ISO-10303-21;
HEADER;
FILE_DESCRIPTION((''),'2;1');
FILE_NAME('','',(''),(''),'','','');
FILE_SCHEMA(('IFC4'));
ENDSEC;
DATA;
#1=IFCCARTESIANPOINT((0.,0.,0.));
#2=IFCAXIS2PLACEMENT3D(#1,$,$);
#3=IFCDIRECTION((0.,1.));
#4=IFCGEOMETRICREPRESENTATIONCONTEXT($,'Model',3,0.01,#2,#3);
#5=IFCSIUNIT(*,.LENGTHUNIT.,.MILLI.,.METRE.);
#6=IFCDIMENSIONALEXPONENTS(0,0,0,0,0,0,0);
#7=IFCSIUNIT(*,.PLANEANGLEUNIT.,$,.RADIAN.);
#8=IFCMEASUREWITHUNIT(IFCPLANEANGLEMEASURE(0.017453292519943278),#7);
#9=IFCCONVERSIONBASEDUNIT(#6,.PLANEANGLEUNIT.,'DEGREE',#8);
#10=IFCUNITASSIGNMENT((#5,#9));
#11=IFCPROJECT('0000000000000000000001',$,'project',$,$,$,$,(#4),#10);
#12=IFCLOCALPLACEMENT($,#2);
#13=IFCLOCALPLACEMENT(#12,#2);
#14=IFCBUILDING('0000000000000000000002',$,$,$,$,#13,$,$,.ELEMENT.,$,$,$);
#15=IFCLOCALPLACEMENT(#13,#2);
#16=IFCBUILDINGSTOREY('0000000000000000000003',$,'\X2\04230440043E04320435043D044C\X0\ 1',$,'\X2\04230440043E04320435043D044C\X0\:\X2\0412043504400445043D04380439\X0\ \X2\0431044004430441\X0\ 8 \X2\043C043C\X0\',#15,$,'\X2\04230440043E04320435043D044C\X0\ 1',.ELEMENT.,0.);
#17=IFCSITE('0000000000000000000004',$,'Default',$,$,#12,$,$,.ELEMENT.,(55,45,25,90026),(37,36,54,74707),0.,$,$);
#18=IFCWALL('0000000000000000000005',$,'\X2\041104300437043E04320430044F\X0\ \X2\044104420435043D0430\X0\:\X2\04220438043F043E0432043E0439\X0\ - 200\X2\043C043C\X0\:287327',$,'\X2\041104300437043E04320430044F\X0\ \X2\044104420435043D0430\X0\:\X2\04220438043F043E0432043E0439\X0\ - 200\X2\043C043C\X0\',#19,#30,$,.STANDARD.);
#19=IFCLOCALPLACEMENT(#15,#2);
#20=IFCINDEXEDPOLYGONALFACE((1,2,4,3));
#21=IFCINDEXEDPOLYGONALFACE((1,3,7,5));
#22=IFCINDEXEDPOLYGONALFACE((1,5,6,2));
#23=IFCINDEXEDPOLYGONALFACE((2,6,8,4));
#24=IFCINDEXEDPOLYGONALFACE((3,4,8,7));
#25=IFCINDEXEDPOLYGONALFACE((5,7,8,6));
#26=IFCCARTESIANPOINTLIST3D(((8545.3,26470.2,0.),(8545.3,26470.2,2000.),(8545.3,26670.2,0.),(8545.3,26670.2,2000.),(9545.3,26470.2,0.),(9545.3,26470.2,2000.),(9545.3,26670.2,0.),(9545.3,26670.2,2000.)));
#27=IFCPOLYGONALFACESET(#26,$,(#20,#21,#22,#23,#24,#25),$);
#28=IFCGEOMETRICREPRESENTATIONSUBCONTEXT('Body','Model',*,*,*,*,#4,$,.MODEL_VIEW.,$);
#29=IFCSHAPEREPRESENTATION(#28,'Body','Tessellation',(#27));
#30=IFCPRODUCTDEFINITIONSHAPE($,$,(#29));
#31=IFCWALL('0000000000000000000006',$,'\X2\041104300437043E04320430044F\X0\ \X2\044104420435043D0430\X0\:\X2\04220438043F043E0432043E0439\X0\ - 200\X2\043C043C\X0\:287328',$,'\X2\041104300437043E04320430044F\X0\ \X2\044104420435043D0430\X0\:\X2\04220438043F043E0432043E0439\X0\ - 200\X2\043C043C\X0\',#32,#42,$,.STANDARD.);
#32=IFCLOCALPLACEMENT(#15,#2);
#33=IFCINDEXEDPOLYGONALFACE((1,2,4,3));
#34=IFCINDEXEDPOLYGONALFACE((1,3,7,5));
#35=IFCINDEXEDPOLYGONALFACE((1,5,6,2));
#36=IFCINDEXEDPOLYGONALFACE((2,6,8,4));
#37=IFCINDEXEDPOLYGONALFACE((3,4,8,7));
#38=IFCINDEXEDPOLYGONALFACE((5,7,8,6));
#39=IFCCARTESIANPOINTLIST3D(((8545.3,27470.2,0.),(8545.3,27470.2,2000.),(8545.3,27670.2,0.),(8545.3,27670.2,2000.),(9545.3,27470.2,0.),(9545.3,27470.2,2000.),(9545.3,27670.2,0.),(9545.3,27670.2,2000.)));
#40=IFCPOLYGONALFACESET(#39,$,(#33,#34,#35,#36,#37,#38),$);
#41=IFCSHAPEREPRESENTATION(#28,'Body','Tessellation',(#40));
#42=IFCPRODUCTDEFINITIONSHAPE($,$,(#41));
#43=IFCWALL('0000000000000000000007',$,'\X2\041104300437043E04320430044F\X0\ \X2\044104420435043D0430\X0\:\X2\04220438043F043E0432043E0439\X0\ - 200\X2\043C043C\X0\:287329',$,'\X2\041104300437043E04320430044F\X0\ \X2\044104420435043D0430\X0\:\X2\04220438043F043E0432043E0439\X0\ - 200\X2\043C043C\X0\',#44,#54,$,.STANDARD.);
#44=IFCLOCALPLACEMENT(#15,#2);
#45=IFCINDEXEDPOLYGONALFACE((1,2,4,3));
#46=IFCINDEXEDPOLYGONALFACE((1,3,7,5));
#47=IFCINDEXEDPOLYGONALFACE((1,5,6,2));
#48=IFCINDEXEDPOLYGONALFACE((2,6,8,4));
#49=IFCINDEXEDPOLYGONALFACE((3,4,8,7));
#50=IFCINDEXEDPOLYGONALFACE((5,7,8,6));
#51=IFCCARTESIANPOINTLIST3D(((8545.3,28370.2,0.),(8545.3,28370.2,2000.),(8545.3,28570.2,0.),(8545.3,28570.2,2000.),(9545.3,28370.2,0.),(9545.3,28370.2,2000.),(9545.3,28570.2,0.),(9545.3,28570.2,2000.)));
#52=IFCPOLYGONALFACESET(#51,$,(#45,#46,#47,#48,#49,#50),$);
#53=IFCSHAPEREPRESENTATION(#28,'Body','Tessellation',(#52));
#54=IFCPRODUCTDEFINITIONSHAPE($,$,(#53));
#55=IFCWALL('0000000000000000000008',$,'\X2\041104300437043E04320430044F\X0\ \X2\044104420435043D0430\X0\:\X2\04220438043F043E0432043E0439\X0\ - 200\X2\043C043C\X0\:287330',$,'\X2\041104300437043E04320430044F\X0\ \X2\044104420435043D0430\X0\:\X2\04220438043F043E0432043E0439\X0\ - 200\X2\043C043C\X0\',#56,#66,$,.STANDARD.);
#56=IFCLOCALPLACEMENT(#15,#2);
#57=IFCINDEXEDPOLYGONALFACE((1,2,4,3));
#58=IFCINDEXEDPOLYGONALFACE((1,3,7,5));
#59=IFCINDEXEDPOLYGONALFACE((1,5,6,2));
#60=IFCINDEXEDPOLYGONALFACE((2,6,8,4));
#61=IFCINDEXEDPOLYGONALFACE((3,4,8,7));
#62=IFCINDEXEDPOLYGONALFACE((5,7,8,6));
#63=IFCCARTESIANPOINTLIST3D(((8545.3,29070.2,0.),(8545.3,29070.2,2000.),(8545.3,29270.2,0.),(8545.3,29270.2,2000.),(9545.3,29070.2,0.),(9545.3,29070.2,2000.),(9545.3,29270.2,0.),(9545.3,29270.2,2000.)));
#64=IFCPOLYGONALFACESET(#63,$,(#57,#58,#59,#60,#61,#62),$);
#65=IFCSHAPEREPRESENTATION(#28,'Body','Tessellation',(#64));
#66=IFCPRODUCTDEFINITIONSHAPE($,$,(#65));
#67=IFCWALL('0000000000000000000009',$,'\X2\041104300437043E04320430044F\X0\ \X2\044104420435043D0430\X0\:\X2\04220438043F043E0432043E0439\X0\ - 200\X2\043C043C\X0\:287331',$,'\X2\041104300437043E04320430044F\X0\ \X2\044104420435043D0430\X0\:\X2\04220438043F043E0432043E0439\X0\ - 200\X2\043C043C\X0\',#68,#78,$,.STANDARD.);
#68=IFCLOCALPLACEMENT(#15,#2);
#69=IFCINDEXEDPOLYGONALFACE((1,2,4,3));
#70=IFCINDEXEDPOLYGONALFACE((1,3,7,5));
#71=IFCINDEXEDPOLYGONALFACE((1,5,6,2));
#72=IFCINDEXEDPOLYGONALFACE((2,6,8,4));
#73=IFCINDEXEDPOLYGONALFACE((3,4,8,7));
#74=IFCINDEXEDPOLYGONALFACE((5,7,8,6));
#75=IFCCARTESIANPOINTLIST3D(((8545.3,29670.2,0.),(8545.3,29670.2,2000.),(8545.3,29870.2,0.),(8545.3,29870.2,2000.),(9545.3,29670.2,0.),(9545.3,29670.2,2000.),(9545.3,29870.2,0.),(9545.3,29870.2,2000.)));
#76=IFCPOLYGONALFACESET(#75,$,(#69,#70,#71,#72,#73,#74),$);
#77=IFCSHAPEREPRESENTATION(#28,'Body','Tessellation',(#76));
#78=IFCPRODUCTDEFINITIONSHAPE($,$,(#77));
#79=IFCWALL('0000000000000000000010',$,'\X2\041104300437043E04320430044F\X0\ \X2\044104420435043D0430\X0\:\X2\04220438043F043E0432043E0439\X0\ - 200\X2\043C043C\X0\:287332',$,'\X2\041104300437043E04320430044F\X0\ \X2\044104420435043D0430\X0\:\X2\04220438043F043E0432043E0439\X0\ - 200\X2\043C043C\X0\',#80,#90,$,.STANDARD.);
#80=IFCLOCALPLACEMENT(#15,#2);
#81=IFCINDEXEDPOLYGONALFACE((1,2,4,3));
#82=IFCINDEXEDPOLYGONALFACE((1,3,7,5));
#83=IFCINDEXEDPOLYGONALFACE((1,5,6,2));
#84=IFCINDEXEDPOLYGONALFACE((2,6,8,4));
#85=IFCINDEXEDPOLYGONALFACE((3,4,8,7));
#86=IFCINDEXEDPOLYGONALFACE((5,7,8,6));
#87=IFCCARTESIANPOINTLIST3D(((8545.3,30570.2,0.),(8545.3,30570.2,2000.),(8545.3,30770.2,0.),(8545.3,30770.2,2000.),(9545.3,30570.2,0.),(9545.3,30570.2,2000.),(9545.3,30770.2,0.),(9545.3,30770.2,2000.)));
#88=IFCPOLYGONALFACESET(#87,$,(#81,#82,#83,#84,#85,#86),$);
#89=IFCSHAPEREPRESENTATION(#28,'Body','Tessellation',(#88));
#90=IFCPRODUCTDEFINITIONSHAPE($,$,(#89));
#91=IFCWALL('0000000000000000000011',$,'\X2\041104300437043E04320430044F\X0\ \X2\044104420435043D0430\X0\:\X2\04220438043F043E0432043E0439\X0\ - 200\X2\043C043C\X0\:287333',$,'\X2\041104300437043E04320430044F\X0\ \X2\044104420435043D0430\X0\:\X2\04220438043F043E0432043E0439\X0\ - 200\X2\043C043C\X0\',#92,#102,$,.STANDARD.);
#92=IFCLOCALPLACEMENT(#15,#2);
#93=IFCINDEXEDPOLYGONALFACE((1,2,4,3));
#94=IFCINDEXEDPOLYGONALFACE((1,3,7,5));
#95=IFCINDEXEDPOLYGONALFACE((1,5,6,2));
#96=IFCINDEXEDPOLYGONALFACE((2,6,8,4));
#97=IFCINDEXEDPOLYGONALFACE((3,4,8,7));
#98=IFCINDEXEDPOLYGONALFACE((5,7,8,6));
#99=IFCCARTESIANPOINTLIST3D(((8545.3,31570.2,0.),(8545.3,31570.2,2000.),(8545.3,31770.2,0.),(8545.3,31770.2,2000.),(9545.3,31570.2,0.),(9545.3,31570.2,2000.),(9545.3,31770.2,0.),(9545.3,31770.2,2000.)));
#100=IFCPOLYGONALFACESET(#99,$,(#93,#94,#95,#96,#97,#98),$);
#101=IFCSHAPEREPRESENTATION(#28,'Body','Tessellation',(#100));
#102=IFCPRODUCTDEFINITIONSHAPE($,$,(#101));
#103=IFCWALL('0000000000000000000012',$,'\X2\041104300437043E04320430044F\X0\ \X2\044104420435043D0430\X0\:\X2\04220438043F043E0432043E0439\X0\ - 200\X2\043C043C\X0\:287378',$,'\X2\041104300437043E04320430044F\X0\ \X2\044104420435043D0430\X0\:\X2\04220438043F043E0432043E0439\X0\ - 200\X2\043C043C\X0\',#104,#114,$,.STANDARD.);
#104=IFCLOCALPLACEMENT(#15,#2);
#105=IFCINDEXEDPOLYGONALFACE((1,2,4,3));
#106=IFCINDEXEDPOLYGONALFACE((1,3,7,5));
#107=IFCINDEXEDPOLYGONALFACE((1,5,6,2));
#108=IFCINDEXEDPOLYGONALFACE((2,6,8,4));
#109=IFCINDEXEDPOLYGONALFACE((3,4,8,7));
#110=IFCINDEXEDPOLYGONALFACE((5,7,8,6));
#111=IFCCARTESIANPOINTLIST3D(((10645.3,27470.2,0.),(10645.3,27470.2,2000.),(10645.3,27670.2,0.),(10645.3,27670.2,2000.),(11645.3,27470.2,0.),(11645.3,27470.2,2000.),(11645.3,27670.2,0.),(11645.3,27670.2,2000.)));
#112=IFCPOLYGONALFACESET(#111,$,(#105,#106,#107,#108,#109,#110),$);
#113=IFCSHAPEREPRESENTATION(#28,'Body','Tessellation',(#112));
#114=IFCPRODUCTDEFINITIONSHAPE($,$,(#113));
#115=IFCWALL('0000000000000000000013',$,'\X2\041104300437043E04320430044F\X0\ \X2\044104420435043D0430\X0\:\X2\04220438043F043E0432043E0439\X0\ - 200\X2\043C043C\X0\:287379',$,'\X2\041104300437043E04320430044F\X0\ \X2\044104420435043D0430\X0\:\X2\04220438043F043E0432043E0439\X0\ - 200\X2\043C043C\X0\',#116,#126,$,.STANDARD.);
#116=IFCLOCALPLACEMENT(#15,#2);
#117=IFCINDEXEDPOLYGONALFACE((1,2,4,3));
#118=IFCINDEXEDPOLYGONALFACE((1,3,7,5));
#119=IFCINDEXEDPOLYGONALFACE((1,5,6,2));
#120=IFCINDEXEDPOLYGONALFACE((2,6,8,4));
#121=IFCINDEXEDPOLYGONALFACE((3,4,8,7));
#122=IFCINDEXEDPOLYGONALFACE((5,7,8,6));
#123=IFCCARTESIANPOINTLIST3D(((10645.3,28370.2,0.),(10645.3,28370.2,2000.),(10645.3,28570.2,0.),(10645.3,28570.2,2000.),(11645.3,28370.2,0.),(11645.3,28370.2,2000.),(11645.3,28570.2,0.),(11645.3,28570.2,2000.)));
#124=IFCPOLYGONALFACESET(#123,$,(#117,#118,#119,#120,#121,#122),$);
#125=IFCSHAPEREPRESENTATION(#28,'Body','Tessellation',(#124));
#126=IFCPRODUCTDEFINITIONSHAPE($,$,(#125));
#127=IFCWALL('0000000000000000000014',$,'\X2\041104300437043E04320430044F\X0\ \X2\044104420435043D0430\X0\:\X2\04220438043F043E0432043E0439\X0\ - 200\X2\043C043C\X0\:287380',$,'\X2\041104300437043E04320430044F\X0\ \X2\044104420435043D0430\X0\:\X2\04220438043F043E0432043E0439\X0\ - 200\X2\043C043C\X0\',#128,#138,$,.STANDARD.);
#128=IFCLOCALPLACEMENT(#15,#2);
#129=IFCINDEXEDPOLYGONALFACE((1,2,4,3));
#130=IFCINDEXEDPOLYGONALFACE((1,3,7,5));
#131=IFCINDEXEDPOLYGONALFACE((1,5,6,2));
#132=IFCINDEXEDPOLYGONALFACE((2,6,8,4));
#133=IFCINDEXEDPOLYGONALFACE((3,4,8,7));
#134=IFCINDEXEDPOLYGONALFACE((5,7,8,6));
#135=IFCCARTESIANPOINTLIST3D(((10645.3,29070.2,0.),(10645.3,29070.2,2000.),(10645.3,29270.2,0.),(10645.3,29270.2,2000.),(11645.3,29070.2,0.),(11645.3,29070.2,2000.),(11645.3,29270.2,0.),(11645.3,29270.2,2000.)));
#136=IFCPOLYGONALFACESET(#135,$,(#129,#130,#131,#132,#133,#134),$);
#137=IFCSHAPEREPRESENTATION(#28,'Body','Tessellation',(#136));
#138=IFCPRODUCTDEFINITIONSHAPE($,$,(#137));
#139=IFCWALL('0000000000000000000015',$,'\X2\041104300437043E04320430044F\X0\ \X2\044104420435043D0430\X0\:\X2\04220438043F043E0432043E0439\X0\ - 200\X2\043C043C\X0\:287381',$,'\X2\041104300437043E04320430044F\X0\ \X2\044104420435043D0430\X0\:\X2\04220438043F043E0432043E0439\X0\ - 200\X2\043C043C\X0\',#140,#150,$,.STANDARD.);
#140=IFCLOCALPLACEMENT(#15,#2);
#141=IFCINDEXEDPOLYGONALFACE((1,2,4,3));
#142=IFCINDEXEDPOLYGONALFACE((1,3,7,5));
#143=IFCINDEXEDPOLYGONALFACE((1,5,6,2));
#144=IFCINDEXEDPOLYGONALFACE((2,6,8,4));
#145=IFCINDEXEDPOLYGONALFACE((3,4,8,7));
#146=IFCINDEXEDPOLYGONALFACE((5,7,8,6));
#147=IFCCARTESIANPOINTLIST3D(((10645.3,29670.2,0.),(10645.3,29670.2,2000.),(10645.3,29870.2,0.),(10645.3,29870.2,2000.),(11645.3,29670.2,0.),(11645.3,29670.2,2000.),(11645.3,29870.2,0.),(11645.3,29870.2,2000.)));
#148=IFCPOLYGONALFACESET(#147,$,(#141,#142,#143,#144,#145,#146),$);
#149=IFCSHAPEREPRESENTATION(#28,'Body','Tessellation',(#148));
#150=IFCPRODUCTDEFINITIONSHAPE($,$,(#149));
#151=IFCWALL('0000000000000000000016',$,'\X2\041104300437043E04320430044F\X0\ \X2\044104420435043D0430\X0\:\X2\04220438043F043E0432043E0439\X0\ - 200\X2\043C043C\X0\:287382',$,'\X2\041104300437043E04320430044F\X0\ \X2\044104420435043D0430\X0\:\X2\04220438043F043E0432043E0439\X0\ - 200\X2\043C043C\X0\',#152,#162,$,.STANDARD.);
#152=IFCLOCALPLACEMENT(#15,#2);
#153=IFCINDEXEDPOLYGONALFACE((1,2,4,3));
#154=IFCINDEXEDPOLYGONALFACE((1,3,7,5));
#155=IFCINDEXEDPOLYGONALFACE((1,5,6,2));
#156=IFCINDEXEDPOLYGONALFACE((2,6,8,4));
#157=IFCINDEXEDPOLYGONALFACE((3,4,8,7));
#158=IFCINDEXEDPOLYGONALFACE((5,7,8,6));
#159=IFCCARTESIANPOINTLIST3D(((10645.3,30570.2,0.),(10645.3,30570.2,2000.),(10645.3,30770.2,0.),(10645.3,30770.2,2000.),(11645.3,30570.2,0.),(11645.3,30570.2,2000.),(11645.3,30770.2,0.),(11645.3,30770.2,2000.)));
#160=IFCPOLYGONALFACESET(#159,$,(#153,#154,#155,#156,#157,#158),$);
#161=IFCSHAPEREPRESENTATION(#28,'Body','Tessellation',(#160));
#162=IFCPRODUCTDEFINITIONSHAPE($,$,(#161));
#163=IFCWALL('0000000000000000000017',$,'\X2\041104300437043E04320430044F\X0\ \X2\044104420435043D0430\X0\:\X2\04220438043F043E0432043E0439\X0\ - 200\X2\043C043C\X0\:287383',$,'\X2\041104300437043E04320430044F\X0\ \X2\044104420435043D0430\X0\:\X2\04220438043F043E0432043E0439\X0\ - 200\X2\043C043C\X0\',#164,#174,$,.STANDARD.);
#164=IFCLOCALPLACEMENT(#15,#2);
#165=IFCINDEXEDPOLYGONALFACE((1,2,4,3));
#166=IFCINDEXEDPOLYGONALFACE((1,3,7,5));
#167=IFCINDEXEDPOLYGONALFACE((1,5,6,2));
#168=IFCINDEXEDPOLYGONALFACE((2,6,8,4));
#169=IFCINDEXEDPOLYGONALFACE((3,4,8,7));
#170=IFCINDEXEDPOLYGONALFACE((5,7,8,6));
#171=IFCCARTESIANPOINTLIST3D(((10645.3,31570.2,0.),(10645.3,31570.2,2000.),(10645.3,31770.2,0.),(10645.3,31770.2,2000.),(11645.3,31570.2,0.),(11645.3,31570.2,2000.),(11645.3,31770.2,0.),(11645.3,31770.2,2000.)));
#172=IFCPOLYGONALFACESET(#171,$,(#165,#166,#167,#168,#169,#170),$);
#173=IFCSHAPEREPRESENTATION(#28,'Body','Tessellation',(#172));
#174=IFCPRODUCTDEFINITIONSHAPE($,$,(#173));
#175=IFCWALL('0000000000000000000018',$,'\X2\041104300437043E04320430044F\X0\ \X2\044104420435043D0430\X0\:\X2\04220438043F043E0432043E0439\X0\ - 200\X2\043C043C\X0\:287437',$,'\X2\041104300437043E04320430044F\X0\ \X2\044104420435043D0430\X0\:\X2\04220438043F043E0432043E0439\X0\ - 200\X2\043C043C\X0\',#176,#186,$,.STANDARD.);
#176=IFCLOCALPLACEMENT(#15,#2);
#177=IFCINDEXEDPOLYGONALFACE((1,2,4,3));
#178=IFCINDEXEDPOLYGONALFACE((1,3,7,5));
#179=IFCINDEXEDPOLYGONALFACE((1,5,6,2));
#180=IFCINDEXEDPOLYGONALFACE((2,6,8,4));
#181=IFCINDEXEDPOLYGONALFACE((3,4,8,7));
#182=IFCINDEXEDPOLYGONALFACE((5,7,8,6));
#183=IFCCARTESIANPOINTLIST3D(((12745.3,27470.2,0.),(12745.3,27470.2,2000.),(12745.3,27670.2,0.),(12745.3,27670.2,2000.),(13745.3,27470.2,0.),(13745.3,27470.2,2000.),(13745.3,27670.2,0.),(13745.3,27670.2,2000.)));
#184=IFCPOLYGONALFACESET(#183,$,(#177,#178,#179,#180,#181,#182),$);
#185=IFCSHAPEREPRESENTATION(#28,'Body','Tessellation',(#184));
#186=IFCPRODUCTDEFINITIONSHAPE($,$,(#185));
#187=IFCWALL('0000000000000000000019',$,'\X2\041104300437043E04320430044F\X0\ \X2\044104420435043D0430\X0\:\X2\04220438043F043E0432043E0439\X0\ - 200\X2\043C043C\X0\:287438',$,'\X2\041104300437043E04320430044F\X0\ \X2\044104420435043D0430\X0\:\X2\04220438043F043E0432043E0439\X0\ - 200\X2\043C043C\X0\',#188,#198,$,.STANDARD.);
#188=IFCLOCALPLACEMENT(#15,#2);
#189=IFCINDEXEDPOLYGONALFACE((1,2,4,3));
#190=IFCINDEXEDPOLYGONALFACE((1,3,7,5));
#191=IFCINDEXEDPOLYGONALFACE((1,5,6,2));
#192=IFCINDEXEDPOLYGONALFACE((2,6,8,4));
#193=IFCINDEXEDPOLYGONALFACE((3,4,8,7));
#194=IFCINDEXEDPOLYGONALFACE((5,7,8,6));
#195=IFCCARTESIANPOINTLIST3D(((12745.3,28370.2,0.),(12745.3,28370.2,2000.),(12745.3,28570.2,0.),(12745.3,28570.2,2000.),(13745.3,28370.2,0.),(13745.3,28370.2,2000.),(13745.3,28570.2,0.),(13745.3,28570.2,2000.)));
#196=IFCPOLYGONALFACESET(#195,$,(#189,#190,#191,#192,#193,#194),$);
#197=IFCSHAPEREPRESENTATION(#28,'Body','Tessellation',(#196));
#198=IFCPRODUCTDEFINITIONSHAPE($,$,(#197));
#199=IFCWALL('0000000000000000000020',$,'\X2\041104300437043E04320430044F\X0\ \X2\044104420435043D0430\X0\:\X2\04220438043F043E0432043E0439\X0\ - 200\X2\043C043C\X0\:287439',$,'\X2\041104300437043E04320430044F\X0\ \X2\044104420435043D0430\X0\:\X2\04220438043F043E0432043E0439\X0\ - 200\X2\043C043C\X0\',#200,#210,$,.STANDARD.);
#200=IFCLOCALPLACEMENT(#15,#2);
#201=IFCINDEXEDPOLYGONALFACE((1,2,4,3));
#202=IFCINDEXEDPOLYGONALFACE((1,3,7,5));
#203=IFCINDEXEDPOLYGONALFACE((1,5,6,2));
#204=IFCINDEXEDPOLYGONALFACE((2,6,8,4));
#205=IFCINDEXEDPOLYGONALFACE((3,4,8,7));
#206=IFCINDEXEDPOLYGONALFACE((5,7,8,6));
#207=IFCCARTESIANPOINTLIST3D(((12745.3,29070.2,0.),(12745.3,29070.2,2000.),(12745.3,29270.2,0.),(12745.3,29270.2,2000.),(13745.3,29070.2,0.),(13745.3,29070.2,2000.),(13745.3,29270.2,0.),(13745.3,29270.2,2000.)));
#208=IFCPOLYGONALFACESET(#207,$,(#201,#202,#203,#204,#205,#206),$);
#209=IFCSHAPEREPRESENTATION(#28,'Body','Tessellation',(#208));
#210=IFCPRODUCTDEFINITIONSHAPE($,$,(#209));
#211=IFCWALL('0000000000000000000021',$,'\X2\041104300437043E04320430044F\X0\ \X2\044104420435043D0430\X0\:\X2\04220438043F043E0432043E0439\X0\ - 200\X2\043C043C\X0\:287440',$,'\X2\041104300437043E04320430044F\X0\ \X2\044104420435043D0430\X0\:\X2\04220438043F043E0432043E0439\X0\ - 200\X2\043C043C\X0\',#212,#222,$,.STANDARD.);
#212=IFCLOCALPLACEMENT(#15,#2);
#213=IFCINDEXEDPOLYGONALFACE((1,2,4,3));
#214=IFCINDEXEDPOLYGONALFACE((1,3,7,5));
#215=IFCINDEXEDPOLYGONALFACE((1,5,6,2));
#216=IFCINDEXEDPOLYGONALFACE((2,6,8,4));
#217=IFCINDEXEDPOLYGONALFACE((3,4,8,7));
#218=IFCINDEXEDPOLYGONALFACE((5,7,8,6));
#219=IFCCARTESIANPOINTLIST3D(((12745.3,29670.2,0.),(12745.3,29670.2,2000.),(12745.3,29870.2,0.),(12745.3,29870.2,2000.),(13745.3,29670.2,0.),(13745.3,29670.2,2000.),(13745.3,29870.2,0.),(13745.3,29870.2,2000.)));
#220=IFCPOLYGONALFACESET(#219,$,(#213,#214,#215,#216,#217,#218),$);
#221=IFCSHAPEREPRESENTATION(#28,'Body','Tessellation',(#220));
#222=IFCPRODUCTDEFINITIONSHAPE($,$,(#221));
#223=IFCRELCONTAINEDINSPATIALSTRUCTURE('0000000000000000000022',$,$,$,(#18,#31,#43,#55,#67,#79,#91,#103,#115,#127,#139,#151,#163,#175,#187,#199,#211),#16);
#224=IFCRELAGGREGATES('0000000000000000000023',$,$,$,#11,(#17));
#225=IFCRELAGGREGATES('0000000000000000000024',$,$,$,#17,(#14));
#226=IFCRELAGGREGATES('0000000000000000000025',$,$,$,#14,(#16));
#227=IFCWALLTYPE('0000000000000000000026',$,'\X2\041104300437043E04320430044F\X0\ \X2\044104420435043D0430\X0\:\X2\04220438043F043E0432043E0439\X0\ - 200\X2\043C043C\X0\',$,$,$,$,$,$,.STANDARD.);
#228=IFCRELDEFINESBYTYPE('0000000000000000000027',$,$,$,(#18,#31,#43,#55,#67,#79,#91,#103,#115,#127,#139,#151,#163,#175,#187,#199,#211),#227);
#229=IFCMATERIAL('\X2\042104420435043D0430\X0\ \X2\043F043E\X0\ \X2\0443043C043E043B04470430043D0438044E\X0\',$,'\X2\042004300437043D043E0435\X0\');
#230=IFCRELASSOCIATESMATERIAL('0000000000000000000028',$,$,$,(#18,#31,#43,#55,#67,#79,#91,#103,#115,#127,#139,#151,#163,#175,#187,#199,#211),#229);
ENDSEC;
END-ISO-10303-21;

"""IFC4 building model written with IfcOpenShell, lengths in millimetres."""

from ifc_helpers import new_model, entity, si_unit, converted_unit, direction, frame, origin, place, context, subcontext, project, spatial, indexed_curve, outline, extrude, material, type_object, element, save


model = new_model("IFC4")

# Units and contexts
model_context = context("Model", 3, precision=0.01, world=origin(), true_north=direction((0.0, 1.0)))
body_context = subcontext(model_context, "Body", "Model", "MODEL_VIEW")
ifc_project = project(units=[si_unit("LENGTHUNIT", "METRE", prefix="MILLI"), converted_unit("PLANEANGLEUNIT", "DEGREE", entity("IfcPlaneAngleMeasure", 0.017453292519943278), si_unit("PLANEANGLEUNIT", "RADIAN"), dimensions=[0, 0, 0, 0, 0, 0, 0])], contexts=[model_context])

# Site, building, storey
site_placement = place(None, origin())
site = spatial("IfcSite", under=ifc_project, at=site_placement, Name="Default", CompositionType="ELEMENT", RefLatitude=(55, 45, 25, 90026), RefLongitude=(37, 36, 54, 74707), RefElevation=0.0)
building_placement = place(site_placement, origin())
building = spatial("IfcBuilding", under=site, at=building_placement, CompositionType="ELEMENT")
storey_placement = place(building_placement, origin())
storey = spatial("IfcBuildingStorey", under=building, at=storey_placement, Name="Уровень 1", ObjectType="Уровень:Верхний брус 8 мм", LongName="Уровень 1", CompositionType="ELEMENT", Elevation=0.0)

# Walls
ifc_material = material(Name="Стена по умолчанию", Category="Разное")
wall_type = type_object("IfcWallType", Name="Базовая стена:Типовой - 200мм", PredefinedType="STANDARD")
for number, where, name in (
    (1, (8545.3, 26570.2, 0.0), "Базовая стена:Типовой - 200мм:287327"),
    (2, (8545.3, 27570.2, 0.0), "Базовая стена:Типовой - 200мм:287328"),
):
    element("IfcWall", number, at=place(storey_placement, frame(where)), inside=storey, type_object=wall_type, material=ifc_material, Name=name, ObjectType="Базовая стена:Типовой - 200мм", PredefinedType="STANDARD", context=body_context, shape_type="SweptSolid", body=[
        extrude(outline(indexed_curve([(1000.0, 100.0), (0.0, 100.0), (0.0, -100.0), (1000.0, -100.0), (1000.0, 100.0)], self_intersect=False)), origin(), (0.0, 0.0, 1.0), 2000.0),
    ])
for number, where, name in (
    (3, (8545.3, 28470.2, 0.0), "Базовая стена:Типовой - 200мм:287329"),
    (4, (8545.3, 29170.2, 0.0), "Базовая стена:Типовой - 200мм:287330"),
):
    element("IfcWall", number, at=place(storey_placement, frame(where)), inside=storey, type_object=wall_type, material=ifc_material, Name=name, ObjectType="Базовая стена:Типовой - 200мм", PredefinedType="STANDARD", context=body_context, shape_type="SweptSolid", body=[
        extrude(outline(indexed_curve([(1000.0, 100.0), (0.0, 100.0), (0.0, -100.0), (1000.0, -100.0), (1000.0, 100.0)], self_intersect=False)), origin(), (0.0, 0.0, 1.0), 2000.0),
    ])
for number, where, name in (
    (5, (8545.3, 29770.2, 0.0), "Базовая стена:Типовой - 200мм:287331"),
    (6, (8545.3, 30670.2, 0.0), "Базовая стена:Типовой - 200мм:287332"),
    (7, (8545.3, 31670.2, 0.0), "Базовая стена:Типовой - 200мм:287333"),
):
    element("IfcWall", number, at=place(storey_placement, frame(where)), inside=storey, type_object=wall_type, material=ifc_material, Name=name, ObjectType="Базовая стена:Типовой - 200мм", PredefinedType="STANDARD", context=body_context, shape_type="SweptSolid", body=[
        extrude(outline(indexed_curve([(1000.0, 100.0), (0.0, 100.0), (0.0, -100.0), (1000.0, -100.0), (1000.0, 100.0)], self_intersect=False)), origin(), (0.0, 0.0, 1.0), 2000.0),
    ])
wall_1_placement = place(storey_placement, frame((10645.3, 27570.2, 0.0)))
element("IfcWall", 8, at=wall_1_placement, inside=storey, type_object=wall_type, material=ifc_material, Name="Базовая стена:Типовой - 200мм:287378", ObjectType="Базовая стена:Типовой - 200мм", PredefinedType="STANDARD", context=body_context, shape_type="SweptSolid", body=[
    extrude(outline(indexed_curve([(1000.0, 100.0), (0.0, 100.0), (0.0, -100.0), (1000.0, -100.0), (1000.0, 100.0)], self_intersect=False)), origin(), (0.0, 0.0, 1.0), 2000.0),
])
for number, where, name in (
    (9, (10645.3, 28470.2, 0.0), "Базовая стена:Типовой - 200мм:287379"),
    (10, (10645.3, 29170.2, 0.0), "Базовая стена:Типовой - 200мм:287380"),
):
    element("IfcWall", number, at=place(storey_placement, frame(where)), inside=storey, type_object=wall_type, material=ifc_material, Name=name, ObjectType="Базовая стена:Типовой - 200мм", PredefinedType="STANDARD", context=body_context, shape_type="SweptSolid", body=[
        extrude(outline(indexed_curve([(1000.0, 100.0), (0.0, 100.0), (0.0, -100.0), (1000.0, -100.0), (1000.0, 100.0)], self_intersect=False)), origin(), (0.0, 0.0, 1.0), 2000.0),
    ])
for number, where, name in (
    (11, (10645.3, 29770.2, 0.0), "Базовая стена:Типовой - 200мм:287381"),
    (12, (10645.3, 30670.2, 0.0), "Базовая стена:Типовой - 200мм:287382"),
    (13, (10645.3, 31670.2, 0.0), "Базовая стена:Типовой - 200мм:287383"),
    (14, (12745.3, 27570.2, 0.0), "Базовая стена:Типовой - 200мм:287437"),
):
    element("IfcWall", number, at=place(storey_placement, frame(where)), inside=storey, type_object=wall_type, material=ifc_material, Name=name, ObjectType="Базовая стена:Типовой - 200мм", PredefinedType="STANDARD", context=body_context, shape_type="SweptSolid", body=[
        extrude(outline(indexed_curve([(1000.0, 100.0), (0.0, 100.0), (0.0, -100.0), (1000.0, -100.0), (1000.0, 100.0)], self_intersect=False)), origin(), (0.0, 0.0, 1.0), 2000.0),
    ])
for number, where, name in (
    (15, (12745.3, 28470.2, 0.0), "Базовая стена:Типовой - 200мм:287438"),
    (16, (12745.3, 29170.2, 0.0), "Базовая стена:Типовой - 200мм:287439"),
):
    element("IfcWall", number, at=place(storey_placement, frame(where)), inside=storey, type_object=wall_type, material=ifc_material, Name=name, ObjectType="Базовая стена:Типовой - 200мм", PredefinedType="STANDARD", context=body_context, shape_type="SweptSolid", body=[
        extrude(outline(indexed_curve([(1000.0, 100.0), (0.0, 100.0), (0.0, -100.0), (1000.0, -100.0), (1000.0, 100.0)], self_intersect=False)), origin(), (0.0, 0.0, 1.0), 2000.0),
    ])
for number, where, name in (
    (17, (12745.3, 29770.2, 0.0), "Базовая стена:Типовой - 200мм:287440"),
):
    element("IfcWall", number, at=place(storey_placement, frame(where)), inside=storey, type_object=wall_type, material=ifc_material, Name=name, ObjectType="Базовая стена:Типовой - 200мм", PredefinedType="STANDARD", context=body_context, shape_type="SweptSolid", body=[
        extrude(outline(indexed_curve([(1000.0, 100.0), (0.0, 100.0), (0.0, -100.0), (1000.0, -100.0), (1000.0, 100.0)], self_intersect=False)), origin(), (0.0, 0.0, 1.0), 2000.0),
    ])

save(model, "model.ifc")
